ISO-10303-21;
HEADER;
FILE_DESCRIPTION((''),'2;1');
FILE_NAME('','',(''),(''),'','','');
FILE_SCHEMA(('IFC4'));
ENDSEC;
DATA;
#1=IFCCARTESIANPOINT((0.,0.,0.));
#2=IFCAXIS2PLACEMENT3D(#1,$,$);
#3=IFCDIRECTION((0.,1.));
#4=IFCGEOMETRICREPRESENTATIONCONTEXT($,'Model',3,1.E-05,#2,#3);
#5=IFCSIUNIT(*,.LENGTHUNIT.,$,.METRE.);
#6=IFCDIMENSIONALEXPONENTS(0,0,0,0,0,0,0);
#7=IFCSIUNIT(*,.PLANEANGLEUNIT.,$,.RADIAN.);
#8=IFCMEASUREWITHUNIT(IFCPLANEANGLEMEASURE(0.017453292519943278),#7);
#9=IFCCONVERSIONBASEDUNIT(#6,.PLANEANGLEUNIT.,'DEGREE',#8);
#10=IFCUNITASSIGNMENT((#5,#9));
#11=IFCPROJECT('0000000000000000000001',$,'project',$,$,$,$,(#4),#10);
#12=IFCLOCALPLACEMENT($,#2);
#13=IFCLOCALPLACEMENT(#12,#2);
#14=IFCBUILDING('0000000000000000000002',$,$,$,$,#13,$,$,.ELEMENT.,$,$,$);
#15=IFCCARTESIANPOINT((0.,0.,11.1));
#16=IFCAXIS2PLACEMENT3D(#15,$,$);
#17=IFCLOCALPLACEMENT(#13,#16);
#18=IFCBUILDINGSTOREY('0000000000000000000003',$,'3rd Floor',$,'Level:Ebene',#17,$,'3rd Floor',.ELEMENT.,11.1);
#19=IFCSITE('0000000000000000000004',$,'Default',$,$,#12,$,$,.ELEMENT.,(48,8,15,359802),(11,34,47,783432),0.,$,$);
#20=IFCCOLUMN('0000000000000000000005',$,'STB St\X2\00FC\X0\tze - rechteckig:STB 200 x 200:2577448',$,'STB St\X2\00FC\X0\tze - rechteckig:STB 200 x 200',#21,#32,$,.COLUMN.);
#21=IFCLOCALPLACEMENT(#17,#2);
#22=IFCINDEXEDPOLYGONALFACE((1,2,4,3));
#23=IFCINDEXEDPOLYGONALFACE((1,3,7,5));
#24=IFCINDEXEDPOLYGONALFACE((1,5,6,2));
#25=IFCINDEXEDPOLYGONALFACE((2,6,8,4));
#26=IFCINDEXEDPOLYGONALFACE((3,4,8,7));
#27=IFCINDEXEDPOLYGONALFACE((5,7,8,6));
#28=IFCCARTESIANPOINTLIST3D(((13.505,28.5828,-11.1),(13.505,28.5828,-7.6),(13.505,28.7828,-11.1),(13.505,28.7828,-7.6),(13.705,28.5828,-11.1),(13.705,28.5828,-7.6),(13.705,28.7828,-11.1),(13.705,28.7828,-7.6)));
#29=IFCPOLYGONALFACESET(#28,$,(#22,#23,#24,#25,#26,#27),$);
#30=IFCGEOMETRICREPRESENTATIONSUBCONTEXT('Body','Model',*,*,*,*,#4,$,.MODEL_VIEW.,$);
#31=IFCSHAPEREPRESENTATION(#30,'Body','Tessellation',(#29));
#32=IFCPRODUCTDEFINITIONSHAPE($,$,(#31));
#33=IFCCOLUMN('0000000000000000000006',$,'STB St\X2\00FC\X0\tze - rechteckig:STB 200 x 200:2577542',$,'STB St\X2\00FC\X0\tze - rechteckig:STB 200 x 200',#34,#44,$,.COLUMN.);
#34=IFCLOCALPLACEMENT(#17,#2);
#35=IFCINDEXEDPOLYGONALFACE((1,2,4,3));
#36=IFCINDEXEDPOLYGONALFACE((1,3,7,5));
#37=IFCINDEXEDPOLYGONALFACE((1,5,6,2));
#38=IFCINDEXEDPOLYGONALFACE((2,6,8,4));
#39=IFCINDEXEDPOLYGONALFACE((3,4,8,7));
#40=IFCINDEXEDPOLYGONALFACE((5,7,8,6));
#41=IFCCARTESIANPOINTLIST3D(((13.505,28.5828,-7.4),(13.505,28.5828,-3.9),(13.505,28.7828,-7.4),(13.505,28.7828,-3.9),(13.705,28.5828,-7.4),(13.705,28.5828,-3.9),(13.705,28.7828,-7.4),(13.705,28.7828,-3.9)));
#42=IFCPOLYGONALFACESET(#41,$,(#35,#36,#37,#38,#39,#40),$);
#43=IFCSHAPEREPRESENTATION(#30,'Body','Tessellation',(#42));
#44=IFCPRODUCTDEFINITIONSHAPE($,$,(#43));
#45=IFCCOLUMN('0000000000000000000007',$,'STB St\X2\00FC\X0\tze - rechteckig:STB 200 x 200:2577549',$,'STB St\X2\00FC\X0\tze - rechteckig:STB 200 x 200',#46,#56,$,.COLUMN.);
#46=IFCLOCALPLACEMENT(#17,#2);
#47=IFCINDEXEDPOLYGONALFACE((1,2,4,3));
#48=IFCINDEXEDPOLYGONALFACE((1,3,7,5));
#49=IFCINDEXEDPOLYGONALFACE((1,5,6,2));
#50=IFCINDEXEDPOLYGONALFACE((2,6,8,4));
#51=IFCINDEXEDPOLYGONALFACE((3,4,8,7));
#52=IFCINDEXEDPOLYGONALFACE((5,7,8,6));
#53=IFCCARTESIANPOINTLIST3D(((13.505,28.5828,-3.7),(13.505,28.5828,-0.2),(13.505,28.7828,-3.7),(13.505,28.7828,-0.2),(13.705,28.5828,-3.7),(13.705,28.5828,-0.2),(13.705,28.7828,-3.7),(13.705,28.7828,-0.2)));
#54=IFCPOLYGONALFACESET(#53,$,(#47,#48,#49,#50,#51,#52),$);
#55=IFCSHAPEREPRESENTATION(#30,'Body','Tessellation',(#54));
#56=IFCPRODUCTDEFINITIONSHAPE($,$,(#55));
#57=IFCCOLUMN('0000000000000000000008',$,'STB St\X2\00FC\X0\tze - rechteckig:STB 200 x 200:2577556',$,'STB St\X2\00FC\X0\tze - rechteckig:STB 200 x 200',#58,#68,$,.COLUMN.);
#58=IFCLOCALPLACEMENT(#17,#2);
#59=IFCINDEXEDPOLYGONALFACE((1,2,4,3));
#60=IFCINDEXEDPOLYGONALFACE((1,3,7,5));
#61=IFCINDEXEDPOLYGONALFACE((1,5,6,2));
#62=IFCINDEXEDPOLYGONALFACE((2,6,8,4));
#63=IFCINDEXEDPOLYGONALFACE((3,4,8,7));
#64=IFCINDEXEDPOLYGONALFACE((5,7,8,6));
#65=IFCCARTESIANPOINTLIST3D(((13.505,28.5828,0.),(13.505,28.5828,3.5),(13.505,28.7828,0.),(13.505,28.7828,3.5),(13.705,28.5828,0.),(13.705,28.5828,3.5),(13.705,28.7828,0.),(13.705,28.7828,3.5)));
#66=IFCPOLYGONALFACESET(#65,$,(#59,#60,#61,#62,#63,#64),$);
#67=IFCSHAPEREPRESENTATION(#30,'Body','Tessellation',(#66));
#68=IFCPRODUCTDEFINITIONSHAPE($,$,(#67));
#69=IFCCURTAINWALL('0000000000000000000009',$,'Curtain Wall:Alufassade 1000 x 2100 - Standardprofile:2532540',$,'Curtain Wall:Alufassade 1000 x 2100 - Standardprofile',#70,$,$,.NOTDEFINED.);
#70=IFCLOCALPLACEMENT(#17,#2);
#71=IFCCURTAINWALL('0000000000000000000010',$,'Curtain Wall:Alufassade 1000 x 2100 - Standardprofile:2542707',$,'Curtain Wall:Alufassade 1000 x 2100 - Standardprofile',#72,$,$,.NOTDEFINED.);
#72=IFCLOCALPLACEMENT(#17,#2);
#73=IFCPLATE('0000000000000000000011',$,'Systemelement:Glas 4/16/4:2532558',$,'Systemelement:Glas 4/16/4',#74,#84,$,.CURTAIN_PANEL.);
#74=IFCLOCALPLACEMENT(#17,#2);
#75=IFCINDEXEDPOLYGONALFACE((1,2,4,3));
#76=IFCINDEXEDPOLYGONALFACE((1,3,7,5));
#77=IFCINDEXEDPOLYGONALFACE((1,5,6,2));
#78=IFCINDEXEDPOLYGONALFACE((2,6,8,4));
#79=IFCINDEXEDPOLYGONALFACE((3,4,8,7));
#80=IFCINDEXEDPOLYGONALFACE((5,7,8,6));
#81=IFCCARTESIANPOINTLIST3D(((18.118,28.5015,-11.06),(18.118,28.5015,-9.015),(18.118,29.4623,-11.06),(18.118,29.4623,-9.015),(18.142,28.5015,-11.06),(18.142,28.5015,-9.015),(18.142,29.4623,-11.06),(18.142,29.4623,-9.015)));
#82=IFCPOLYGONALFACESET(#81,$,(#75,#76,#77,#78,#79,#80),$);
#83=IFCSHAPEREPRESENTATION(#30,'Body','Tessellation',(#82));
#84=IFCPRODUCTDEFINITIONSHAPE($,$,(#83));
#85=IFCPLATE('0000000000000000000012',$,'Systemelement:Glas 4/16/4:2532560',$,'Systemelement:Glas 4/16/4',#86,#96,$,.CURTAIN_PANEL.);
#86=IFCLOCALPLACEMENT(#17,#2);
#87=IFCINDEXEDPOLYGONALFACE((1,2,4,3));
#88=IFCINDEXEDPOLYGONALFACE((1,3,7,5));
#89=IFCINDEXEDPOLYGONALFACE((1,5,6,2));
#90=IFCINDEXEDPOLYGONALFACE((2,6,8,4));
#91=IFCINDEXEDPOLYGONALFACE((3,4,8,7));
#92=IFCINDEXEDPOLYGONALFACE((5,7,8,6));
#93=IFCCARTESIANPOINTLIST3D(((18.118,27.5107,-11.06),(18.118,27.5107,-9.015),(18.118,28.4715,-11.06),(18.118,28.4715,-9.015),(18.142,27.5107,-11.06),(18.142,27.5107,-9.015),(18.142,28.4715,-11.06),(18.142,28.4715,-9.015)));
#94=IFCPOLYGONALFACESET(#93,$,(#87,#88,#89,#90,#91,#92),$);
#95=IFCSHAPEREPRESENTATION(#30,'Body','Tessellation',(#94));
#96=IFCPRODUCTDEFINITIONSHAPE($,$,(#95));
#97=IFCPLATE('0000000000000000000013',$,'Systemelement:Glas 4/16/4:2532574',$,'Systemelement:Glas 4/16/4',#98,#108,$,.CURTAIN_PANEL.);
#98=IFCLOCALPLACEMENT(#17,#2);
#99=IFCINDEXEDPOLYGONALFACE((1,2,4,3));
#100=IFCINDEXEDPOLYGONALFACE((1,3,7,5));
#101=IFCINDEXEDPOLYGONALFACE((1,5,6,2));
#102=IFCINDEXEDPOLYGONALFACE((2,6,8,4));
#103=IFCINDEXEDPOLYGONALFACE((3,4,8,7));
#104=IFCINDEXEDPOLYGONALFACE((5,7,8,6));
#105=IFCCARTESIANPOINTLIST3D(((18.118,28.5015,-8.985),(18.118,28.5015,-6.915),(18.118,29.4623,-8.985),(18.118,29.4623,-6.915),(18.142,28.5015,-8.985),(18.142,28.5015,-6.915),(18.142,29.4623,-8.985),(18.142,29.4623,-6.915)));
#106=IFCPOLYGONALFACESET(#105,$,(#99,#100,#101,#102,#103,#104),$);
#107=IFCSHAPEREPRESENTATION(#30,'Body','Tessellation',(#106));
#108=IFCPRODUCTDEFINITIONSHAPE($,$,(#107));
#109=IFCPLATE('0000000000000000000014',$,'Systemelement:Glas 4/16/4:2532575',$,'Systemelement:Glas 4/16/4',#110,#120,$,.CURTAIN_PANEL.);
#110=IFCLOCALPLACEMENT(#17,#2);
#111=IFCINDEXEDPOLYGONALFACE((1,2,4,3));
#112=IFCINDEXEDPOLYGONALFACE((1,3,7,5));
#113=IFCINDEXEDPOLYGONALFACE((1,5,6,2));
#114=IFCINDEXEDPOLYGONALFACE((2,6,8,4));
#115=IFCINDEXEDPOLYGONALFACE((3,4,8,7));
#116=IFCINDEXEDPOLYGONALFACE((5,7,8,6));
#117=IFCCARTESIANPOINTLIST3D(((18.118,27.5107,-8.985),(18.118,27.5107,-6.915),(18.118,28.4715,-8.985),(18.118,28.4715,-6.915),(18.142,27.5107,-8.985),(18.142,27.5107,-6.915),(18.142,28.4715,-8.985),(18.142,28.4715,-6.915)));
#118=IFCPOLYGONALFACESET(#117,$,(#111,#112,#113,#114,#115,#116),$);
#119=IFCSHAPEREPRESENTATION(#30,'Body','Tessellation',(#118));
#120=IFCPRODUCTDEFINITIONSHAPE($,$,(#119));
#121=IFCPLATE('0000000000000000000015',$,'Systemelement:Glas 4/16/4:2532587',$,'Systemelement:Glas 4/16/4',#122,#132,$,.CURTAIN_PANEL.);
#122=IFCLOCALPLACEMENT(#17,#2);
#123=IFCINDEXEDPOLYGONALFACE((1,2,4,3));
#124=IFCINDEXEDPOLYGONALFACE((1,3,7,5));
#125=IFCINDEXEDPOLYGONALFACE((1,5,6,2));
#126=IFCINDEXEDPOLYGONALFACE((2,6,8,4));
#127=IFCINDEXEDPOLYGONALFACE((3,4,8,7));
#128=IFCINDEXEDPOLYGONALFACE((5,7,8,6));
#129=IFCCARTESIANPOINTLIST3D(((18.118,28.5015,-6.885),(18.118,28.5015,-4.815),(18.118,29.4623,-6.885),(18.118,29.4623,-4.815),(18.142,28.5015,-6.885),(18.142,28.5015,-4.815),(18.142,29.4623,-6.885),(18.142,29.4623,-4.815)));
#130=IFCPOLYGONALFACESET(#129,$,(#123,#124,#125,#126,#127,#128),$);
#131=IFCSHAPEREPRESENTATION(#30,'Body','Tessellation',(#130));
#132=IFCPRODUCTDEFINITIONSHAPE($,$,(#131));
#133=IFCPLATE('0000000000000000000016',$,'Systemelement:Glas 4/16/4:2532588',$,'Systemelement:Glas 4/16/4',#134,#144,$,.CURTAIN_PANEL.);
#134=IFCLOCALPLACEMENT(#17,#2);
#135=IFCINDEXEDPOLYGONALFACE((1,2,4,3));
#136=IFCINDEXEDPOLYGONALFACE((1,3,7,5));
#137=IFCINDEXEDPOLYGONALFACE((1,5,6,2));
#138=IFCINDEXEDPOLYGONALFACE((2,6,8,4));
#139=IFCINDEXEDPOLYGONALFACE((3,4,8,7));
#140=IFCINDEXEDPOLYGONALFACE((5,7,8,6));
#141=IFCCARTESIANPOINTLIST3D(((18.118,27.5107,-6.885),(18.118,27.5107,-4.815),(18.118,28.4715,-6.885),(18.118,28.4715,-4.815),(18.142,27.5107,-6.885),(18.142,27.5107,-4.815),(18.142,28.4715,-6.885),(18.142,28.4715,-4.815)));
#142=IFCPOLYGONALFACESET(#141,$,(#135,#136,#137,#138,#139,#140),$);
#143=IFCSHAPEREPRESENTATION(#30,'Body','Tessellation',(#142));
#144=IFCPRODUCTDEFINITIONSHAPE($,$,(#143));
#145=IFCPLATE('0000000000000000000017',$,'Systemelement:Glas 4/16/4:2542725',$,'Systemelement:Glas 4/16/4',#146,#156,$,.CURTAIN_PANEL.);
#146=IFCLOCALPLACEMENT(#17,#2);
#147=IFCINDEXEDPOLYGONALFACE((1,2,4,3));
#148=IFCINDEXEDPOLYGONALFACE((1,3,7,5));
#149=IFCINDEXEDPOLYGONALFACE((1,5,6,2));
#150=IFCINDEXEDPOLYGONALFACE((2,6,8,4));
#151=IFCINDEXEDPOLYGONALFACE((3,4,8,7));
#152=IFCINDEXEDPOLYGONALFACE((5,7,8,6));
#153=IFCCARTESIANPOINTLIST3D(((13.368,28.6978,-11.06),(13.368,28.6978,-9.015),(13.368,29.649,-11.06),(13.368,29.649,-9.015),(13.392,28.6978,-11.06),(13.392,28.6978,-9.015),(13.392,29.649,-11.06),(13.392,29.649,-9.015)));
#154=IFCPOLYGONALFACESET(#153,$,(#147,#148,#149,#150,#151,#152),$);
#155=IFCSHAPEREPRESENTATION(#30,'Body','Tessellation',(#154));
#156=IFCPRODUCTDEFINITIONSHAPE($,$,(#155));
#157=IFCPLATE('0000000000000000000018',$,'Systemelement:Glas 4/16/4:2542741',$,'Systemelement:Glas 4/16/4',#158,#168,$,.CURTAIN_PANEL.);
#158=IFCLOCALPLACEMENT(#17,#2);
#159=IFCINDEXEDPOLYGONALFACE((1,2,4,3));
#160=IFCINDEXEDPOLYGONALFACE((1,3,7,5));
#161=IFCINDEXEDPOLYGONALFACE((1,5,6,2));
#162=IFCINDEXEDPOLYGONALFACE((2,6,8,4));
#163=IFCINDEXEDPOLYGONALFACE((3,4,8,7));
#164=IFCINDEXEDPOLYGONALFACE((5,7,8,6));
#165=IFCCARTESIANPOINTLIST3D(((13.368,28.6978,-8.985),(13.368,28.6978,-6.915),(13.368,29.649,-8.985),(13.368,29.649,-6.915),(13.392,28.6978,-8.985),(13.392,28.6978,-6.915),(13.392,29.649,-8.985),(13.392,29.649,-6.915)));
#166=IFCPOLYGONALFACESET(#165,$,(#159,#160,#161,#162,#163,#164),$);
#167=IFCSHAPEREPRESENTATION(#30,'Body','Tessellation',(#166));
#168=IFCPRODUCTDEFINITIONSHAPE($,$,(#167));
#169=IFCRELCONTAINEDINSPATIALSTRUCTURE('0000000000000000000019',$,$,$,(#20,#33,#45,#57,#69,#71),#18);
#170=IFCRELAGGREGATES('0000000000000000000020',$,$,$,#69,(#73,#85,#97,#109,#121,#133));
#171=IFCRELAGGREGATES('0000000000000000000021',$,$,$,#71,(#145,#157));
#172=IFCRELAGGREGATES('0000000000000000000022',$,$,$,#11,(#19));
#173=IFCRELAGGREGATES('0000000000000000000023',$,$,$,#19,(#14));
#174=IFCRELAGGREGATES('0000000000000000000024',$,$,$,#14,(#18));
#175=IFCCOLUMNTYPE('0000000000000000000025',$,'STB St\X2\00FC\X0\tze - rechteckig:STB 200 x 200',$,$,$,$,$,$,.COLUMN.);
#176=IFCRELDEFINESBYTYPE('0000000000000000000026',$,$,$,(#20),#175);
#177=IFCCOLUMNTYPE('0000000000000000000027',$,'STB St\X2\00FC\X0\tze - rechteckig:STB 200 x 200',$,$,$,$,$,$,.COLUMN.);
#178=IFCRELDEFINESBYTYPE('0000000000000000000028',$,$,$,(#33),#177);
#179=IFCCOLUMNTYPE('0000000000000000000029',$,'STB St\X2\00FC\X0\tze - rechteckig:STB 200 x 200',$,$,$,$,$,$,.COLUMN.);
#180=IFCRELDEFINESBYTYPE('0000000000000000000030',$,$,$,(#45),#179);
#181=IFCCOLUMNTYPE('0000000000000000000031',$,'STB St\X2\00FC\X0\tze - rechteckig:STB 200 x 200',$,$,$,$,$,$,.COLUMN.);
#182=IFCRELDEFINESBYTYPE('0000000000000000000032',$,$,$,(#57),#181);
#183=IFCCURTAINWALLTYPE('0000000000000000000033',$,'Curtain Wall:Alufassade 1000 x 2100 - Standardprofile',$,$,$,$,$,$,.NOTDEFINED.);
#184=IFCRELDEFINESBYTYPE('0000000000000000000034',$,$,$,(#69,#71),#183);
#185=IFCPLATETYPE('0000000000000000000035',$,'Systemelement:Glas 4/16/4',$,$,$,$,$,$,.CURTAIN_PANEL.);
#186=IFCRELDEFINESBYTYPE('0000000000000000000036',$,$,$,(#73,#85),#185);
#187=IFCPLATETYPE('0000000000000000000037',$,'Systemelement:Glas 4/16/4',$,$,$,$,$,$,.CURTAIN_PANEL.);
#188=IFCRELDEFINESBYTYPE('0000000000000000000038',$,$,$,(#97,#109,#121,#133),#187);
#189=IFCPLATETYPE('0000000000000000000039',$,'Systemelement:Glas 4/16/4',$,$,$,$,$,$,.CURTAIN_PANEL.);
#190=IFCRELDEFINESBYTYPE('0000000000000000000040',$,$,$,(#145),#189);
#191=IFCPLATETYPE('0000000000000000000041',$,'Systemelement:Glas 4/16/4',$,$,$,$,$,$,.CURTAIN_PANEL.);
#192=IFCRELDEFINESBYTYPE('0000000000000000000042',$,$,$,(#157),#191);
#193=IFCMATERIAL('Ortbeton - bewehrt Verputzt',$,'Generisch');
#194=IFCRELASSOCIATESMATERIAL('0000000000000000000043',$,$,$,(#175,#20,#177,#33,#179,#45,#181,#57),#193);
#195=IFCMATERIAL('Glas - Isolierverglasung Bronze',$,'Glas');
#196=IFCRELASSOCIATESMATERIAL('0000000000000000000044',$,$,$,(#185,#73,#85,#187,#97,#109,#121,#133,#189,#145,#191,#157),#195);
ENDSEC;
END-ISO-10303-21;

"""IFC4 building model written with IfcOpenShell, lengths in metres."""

from ifc_helpers import new_model, entity, si_unit, converted_unit, direction, frame, origin, place, context, subcontext, project, spatial, indexed_curve, outline, extrude, source, transform, mapped, material, type_object, type_shapes, element, aggregate, save


model = new_model("IFC4")

# Units and contexts
model_context = context("Model", 3, precision=1e-05, world=origin(), true_north=direction((0.0, 1.0)))
body_context = subcontext(model_context, "Body", "Model", "MODEL_VIEW")
ifc_project = project(units=[si_unit("LENGTHUNIT", "METRE"), converted_unit("PLANEANGLEUNIT", "DEGREE", entity("IfcPlaneAngleMeasure", 0.017453292519943278), si_unit("PLANEANGLEUNIT", "RADIAN"), dimensions=[0, 0, 0, 0, 0, 0, 0])], contexts=[model_context])

# Site, building, storey
site_placement = place(None, origin())
site = spatial("IfcSite", under=ifc_project, at=site_placement, Name="Default", CompositionType="ELEMENT", RefLatitude=(48, 8, 15, 359802), RefLongitude=(11, 34, 47, 783432), RefElevation=0.0)
building_placement = place(site_placement, origin())
building = spatial("IfcBuilding", under=site, at=building_placement, CompositionType="ELEMENT")
storey_placement = place(building_placement, frame((0.0, 0.0, 11.1)))
storey = spatial("IfcBuildingStorey", under=building, at=storey_placement, Name="3rd Floor", ObjectType="Level:Ebene", LongName="3rd Floor", CompositionType="ELEMENT", Elevation=11.1)

# Columns
ifc_material_1 = material(Name="Ortbeton - bewehrt Verputzt", Category="Generisch")
column_type_1 = type_object("IfcColumnType", Name="STB Stütze - rechteckig:STB 200 x 200", PredefinedType="COLUMN", material=ifc_material_1)
shared_shape_1 = source(origin(), body_context, "Body", "SweptSolid", [
    extrude(outline(indexed_curve([(-0.1, -0.1), (0.1, -0.1), (0.1, 0.1), (-0.1, 0.1), (-0.1, -0.1)], self_intersect=False)), frame((0.0, 0.0, 0.0), z_axis=(0.0, 0.0, 1.0), x_axis=(-1.0, 0.0, 0.0)), (0.0, 0.0, 1.0), 3.5),
])
type_shapes(column_type_1, [shared_shape_1])
column_1_placement = place(storey_placement, frame((13.605, 28.6828, -11.1)))
element("IfcColumn", 1, at=column_1_placement, inside=storey, type_object=column_type_1, material=ifc_material_1, Name="STB Stütze - rechteckig:STB 200 x 200:2577448", ObjectType="STB Stütze - rechteckig:STB 200 x 200", PredefinedType="COLUMN", context=body_context, shape_type="MappedRepresentation", body=[
    mapped(shared_shape_1, transform((0.0, 0.0, 0.0), scale=1.0)),
])
column_type_2 = type_object("IfcColumnType", Name="STB Stütze - rechteckig:STB 200 x 200", PredefinedType="COLUMN", material=ifc_material_1)
shared_shape_2 = source(origin(), body_context, "Body", "SweptSolid", [
    extrude(outline(indexed_curve([(-0.1, -0.1), (0.1, -0.1), (0.1, 0.1), (-0.1, 0.1), (-0.1, -0.1)], self_intersect=False)), frame((0.0, 0.0, 3.7), z_axis=(0.0, 0.0, 1.0), x_axis=(-1.0, 0.0, 0.0)), (0.0, 0.0, 1.0), 3.5),
])
type_shapes(column_type_2, [shared_shape_2])
column_2_placement = place(storey_placement, frame((13.605, 28.6828, -11.1)))
element("IfcColumn", 2, at=column_2_placement, inside=storey, type_object=column_type_2, material=ifc_material_1, Name="STB Stütze - rechteckig:STB 200 x 200:2577542", ObjectType="STB Stütze - rechteckig:STB 200 x 200", PredefinedType="COLUMN", context=body_context, shape_type="MappedRepresentation", body=[
    mapped(shared_shape_2, transform((0.0, 0.0, 0.0), scale=1.0)),
])
column_type_3 = type_object("IfcColumnType", Name="STB Stütze - rechteckig:STB 200 x 200", PredefinedType="COLUMN", material=ifc_material_1)
shared_shape_3 = source(origin(), body_context, "Body", "SweptSolid", [
    extrude(outline(indexed_curve([(-0.1, -0.1), (0.1, -0.1), (0.1, 0.1), (-0.1, 0.1), (-0.1, -0.1)], self_intersect=False)), frame((0.0, 0.0, 7.4), z_axis=(0.0, 0.0, 1.0), x_axis=(-1.0, 0.0, 0.0)), (0.0, 0.0, 1.0), 3.5),
])
type_shapes(column_type_3, [shared_shape_3])
column_3_placement = place(storey_placement, frame((13.605, 28.6828, -11.1)))
element("IfcColumn", 3, at=column_3_placement, inside=storey, type_object=column_type_3, material=ifc_material_1, Name="STB Stütze - rechteckig:STB 200 x 200:2577549", ObjectType="STB Stütze - rechteckig:STB 200 x 200", PredefinedType="COLUMN", context=body_context, shape_type="MappedRepresentation", body=[
    mapped(shared_shape_3, transform((0.0, 0.0, 0.0), scale=1.0)),
])
column_type_4 = type_object("IfcColumnType", Name="STB Stütze - rechteckig:STB 200 x 200", PredefinedType="COLUMN", material=ifc_material_1)
shared_shape_4 = source(origin(), body_context, "Body", "SweptSolid", [
    extrude(outline(indexed_curve([(-0.1, -0.1), (0.1, -0.1), (0.1, 0.1), (-0.1, 0.1), (-0.1, -0.1)], self_intersect=False)), frame((0.0, 0.0, 11.1), z_axis=(0.0, 0.0, 1.0), x_axis=(-1.0, 0.0, 0.0)), (0.0, 0.0, 1.0), 3.5),
])
type_shapes(column_type_4, [shared_shape_4])
column_4_placement = place(storey_placement, frame((13.605, 28.6828, -11.1)))
element("IfcColumn", 4, at=column_4_placement, inside=storey, type_object=column_type_4, material=ifc_material_1, Name="STB Stütze - rechteckig:STB 200 x 200:2577556", ObjectType="STB Stütze - rechteckig:STB 200 x 200", PredefinedType="COLUMN", context=body_context, shape_type="MappedRepresentation", body=[
    mapped(shared_shape_4, transform((0.0, 0.0, 0.0), scale=1.0)),
])

# Curtain walls
curtain_wall_type = type_object("IfcCurtainWallType", Name="Curtain Wall:Alufassade 1000 x 2100 - Standardprofile", PredefinedType="NOTDEFINED")
curtain_wall_1_placement = place(storey_placement, frame((0.0, 0.0, -11.1)))
curtain_wall_1 = element("IfcCurtainWall", 5, at=curtain_wall_1_placement, inside=storey, type_object=curtain_wall_type, Name="Curtain Wall:Alufassade 1000 x 2100 - Standardprofile:2532540", ObjectType="Curtain Wall:Alufassade 1000 x 2100 - Standardprofile", PredefinedType="NOTDEFINED")
curtain_wall_2_placement = place(storey_placement, frame((0.0, 0.0, -11.1)))
curtain_wall_2 = element("IfcCurtainWall", 6, at=curtain_wall_2_placement, inside=storey, type_object=curtain_wall_type, Name="Curtain Wall:Alufassade 1000 x 2100 - Standardprofile:2542707", ObjectType="Curtain Wall:Alufassade 1000 x 2100 - Standardprofile", PredefinedType="NOTDEFINED")

# Plates
ifc_material_2 = material(Name="Glas - Isolierverglasung Bronze", Category="Glas")
plate_type_1 = type_object("IfcPlateType", Name="Systemelement:Glas 4/16/4", PredefinedType="CURTAIN_PANEL", material=ifc_material_2)
shared_shape_5 = source(origin(), body_context, "Body", "SweptSolid", [
    extrude(outline(indexed_curve([(-0.012, -0.4804), (0.012, -0.4804), (0.012, 0.4804), (-0.012, 0.4804), (-0.012, -0.4804)], self_intersect=False)), frame((0.0, 0.0, 0.0), z_axis=(0.0, 0.0, 1.0), x_axis=(0.0, 1.0, 0.0)), (0.0, 0.0, 1.0), 2.045),
])
type_shapes(plate_type_1, [shared_shape_5])
plate_1_placement = place(curtain_wall_1_placement, frame((18.13, 28.9819, 0.04), z_axis=(0.0, 0.0, 1.0), x_axis=(0.0, -1.0, 0.0)))
plate_1 = element("IfcPlate", 7, at=plate_1_placement, type_object=plate_type_1, material=ifc_material_2, Name="Systemelement:Glas 4/16/4:2532558", ObjectType="Systemelement:Glas 4/16/4", PredefinedType="CURTAIN_PANEL", context=body_context, shape_type="MappedRepresentation", body=[
    mapped(shared_shape_5, transform((0.0, 0.0, 0.0), scale=1.0)),
])
plate_2_placement = place(curtain_wall_1_placement, frame((18.13, 27.9911, 0.04), z_axis=(0.0, 0.0, 1.0), x_axis=(0.0, -1.0, 0.0)))
plate_2 = element("IfcPlate", 8, at=plate_2_placement, type_object=plate_type_1, material=ifc_material_2, Name="Systemelement:Glas 4/16/4:2532560", ObjectType="Systemelement:Glas 4/16/4", PredefinedType="CURTAIN_PANEL", context=body_context, shape_type="MappedRepresentation", body=[
    mapped(shared_shape_5, transform((0.0, 0.0, 0.0), scale=1.0)),
])
plate_type_2 = type_object("IfcPlateType", Name="Systemelement:Glas 4/16/4", PredefinedType="CURTAIN_PANEL", material=ifc_material_2)
shared_shape_6 = source(origin(), body_context, "Body", "SweptSolid", [
    extrude(outline(indexed_curve([(-0.012, -0.4804), (0.012, -0.4804), (0.012, 0.4804), (-0.012, 0.4804), (-0.012, -0.4804)], self_intersect=False)), frame((0.0, 0.0, 0.0), z_axis=(0.0, 0.0, 1.0), x_axis=(0.0, 1.0, 0.0)), (0.0, 0.0, 1.0), 2.07),
])
type_shapes(plate_type_2, [shared_shape_6])
plate_3_placement = place(curtain_wall_1_placement, frame((18.13, 28.9819, 2.115), z_axis=(0.0, 0.0, 1.0), x_axis=(0.0, -1.0, 0.0)))
plate_3 = element("IfcPlate", 9, at=plate_3_placement, type_object=plate_type_2, material=ifc_material_2, Name="Systemelement:Glas 4/16/4:2532574", ObjectType="Systemelement:Glas 4/16/4", PredefinedType="CURTAIN_PANEL", context=body_context, shape_type="MappedRepresentation", body=[
    mapped(shared_shape_6, transform((0.0, 0.0, 0.0), scale=1.0)),
])
plate_4_placement = place(curtain_wall_1_placement, frame((18.13, 27.9911, 2.115), z_axis=(0.0, 0.0, 1.0), x_axis=(0.0, -1.0, 0.0)))
plate_4 = element("IfcPlate", 10, at=plate_4_placement, type_object=plate_type_2, material=ifc_material_2, Name="Systemelement:Glas 4/16/4:2532575", ObjectType="Systemelement:Glas 4/16/4", PredefinedType="CURTAIN_PANEL", context=body_context, shape_type="MappedRepresentation", body=[
    mapped(shared_shape_6, transform((0.0, 0.0, 0.0), scale=1.0)),
])
plate_5_placement = place(curtain_wall_1_placement, frame((18.13, 28.9819, 4.215), z_axis=(0.0, 0.0, 1.0), x_axis=(0.0, -1.0, 0.0)))
plate_5 = element("IfcPlate", 11, at=plate_5_placement, type_object=plate_type_2, material=ifc_material_2, Name="Systemelement:Glas 4/16/4:2532587", ObjectType="Systemelement:Glas 4/16/4", PredefinedType="CURTAIN_PANEL", context=body_context, shape_type="MappedRepresentation", body=[
    mapped(shared_shape_6, transform((0.0, 0.0, 0.0), scale=1.0)),
])
plate_6_placement = place(curtain_wall_1_placement, frame((18.13, 27.9911, 4.215), z_axis=(0.0, 0.0, 1.0), x_axis=(0.0, -1.0, 0.0)))
plate_6 = element("IfcPlate", 12, at=plate_6_placement, type_object=plate_type_2, material=ifc_material_2, Name="Systemelement:Glas 4/16/4:2532588", ObjectType="Systemelement:Glas 4/16/4", PredefinedType="CURTAIN_PANEL", context=body_context, shape_type="MappedRepresentation", body=[
    mapped(shared_shape_6, transform((0.0, 0.0, 0.0), scale=1.0)),
])
aggregate(curtain_wall_1, [plate_1, plate_2, plate_3, plate_4, plate_5, plate_6])
plate_type_3 = type_object("IfcPlateType", Name="Systemelement:Glas 4/16/4", PredefinedType="CURTAIN_PANEL", material=ifc_material_2)
shared_shape_7 = source(origin(), body_context, "Body", "SweptSolid", [
    extrude(outline(indexed_curve([(-0.012, -0.4756), (0.012, -0.4756), (0.012, 0.4756), (-0.012, 0.4756), (-0.012, -0.4756)], self_intersect=False)), frame((0.0, 0.0, 0.0), z_axis=(0.0, 0.0, 1.0), x_axis=(0.0, 1.0, 0.0)), (0.0, 0.0, 1.0), 2.045),
])
type_shapes(plate_type_3, [shared_shape_7])
plate_7_placement = place(curtain_wall_2_placement, frame((13.38, 29.1734, 0.04), z_axis=(0.0, 0.0, 1.0), x_axis=(0.0, -1.0, 0.0)))
plate_7 = element("IfcPlate", 13, at=plate_7_placement, type_object=plate_type_3, material=ifc_material_2, Name="Systemelement:Glas 4/16/4:2542725", ObjectType="Systemelement:Glas 4/16/4", PredefinedType="CURTAIN_PANEL", context=body_context, shape_type="MappedRepresentation", body=[
    mapped(shared_shape_7, transform((0.0, 0.0, 0.0), scale=1.0)),
])
plate_type_4 = type_object("IfcPlateType", Name="Systemelement:Glas 4/16/4", PredefinedType="CURTAIN_PANEL", material=ifc_material_2)
shared_shape_8 = source(origin(), body_context, "Body", "SweptSolid", [
    extrude(outline(indexed_curve([(-0.012, -0.4756), (0.012, -0.4756), (0.012, 0.4756), (-0.012, 0.4756), (-0.012, -0.4756)], self_intersect=False)), frame((0.0, 0.0, 0.0), z_axis=(0.0, 0.0, 1.0), x_axis=(0.0, 1.0, 0.0)), (0.0, 0.0, 1.0), 2.07),
])
type_shapes(plate_type_4, [shared_shape_8])
plate_8_placement = place(curtain_wall_2_placement, frame((13.38, 29.1734, 2.115), z_axis=(0.0, 0.0, 1.0), x_axis=(0.0, -1.0, 0.0)))
plate_8 = element("IfcPlate", 14, at=plate_8_placement, type_object=plate_type_4, material=ifc_material_2, Name="Systemelement:Glas 4/16/4:2542741", ObjectType="Systemelement:Glas 4/16/4", PredefinedType="CURTAIN_PANEL", context=body_context, shape_type="MappedRepresentation", body=[
    mapped(shared_shape_8, transform((0.0, 0.0, 0.0), scale=1.0)),
])
aggregate(curtain_wall_2, [plate_7, plate_8])

save(model, "model.ifc")
